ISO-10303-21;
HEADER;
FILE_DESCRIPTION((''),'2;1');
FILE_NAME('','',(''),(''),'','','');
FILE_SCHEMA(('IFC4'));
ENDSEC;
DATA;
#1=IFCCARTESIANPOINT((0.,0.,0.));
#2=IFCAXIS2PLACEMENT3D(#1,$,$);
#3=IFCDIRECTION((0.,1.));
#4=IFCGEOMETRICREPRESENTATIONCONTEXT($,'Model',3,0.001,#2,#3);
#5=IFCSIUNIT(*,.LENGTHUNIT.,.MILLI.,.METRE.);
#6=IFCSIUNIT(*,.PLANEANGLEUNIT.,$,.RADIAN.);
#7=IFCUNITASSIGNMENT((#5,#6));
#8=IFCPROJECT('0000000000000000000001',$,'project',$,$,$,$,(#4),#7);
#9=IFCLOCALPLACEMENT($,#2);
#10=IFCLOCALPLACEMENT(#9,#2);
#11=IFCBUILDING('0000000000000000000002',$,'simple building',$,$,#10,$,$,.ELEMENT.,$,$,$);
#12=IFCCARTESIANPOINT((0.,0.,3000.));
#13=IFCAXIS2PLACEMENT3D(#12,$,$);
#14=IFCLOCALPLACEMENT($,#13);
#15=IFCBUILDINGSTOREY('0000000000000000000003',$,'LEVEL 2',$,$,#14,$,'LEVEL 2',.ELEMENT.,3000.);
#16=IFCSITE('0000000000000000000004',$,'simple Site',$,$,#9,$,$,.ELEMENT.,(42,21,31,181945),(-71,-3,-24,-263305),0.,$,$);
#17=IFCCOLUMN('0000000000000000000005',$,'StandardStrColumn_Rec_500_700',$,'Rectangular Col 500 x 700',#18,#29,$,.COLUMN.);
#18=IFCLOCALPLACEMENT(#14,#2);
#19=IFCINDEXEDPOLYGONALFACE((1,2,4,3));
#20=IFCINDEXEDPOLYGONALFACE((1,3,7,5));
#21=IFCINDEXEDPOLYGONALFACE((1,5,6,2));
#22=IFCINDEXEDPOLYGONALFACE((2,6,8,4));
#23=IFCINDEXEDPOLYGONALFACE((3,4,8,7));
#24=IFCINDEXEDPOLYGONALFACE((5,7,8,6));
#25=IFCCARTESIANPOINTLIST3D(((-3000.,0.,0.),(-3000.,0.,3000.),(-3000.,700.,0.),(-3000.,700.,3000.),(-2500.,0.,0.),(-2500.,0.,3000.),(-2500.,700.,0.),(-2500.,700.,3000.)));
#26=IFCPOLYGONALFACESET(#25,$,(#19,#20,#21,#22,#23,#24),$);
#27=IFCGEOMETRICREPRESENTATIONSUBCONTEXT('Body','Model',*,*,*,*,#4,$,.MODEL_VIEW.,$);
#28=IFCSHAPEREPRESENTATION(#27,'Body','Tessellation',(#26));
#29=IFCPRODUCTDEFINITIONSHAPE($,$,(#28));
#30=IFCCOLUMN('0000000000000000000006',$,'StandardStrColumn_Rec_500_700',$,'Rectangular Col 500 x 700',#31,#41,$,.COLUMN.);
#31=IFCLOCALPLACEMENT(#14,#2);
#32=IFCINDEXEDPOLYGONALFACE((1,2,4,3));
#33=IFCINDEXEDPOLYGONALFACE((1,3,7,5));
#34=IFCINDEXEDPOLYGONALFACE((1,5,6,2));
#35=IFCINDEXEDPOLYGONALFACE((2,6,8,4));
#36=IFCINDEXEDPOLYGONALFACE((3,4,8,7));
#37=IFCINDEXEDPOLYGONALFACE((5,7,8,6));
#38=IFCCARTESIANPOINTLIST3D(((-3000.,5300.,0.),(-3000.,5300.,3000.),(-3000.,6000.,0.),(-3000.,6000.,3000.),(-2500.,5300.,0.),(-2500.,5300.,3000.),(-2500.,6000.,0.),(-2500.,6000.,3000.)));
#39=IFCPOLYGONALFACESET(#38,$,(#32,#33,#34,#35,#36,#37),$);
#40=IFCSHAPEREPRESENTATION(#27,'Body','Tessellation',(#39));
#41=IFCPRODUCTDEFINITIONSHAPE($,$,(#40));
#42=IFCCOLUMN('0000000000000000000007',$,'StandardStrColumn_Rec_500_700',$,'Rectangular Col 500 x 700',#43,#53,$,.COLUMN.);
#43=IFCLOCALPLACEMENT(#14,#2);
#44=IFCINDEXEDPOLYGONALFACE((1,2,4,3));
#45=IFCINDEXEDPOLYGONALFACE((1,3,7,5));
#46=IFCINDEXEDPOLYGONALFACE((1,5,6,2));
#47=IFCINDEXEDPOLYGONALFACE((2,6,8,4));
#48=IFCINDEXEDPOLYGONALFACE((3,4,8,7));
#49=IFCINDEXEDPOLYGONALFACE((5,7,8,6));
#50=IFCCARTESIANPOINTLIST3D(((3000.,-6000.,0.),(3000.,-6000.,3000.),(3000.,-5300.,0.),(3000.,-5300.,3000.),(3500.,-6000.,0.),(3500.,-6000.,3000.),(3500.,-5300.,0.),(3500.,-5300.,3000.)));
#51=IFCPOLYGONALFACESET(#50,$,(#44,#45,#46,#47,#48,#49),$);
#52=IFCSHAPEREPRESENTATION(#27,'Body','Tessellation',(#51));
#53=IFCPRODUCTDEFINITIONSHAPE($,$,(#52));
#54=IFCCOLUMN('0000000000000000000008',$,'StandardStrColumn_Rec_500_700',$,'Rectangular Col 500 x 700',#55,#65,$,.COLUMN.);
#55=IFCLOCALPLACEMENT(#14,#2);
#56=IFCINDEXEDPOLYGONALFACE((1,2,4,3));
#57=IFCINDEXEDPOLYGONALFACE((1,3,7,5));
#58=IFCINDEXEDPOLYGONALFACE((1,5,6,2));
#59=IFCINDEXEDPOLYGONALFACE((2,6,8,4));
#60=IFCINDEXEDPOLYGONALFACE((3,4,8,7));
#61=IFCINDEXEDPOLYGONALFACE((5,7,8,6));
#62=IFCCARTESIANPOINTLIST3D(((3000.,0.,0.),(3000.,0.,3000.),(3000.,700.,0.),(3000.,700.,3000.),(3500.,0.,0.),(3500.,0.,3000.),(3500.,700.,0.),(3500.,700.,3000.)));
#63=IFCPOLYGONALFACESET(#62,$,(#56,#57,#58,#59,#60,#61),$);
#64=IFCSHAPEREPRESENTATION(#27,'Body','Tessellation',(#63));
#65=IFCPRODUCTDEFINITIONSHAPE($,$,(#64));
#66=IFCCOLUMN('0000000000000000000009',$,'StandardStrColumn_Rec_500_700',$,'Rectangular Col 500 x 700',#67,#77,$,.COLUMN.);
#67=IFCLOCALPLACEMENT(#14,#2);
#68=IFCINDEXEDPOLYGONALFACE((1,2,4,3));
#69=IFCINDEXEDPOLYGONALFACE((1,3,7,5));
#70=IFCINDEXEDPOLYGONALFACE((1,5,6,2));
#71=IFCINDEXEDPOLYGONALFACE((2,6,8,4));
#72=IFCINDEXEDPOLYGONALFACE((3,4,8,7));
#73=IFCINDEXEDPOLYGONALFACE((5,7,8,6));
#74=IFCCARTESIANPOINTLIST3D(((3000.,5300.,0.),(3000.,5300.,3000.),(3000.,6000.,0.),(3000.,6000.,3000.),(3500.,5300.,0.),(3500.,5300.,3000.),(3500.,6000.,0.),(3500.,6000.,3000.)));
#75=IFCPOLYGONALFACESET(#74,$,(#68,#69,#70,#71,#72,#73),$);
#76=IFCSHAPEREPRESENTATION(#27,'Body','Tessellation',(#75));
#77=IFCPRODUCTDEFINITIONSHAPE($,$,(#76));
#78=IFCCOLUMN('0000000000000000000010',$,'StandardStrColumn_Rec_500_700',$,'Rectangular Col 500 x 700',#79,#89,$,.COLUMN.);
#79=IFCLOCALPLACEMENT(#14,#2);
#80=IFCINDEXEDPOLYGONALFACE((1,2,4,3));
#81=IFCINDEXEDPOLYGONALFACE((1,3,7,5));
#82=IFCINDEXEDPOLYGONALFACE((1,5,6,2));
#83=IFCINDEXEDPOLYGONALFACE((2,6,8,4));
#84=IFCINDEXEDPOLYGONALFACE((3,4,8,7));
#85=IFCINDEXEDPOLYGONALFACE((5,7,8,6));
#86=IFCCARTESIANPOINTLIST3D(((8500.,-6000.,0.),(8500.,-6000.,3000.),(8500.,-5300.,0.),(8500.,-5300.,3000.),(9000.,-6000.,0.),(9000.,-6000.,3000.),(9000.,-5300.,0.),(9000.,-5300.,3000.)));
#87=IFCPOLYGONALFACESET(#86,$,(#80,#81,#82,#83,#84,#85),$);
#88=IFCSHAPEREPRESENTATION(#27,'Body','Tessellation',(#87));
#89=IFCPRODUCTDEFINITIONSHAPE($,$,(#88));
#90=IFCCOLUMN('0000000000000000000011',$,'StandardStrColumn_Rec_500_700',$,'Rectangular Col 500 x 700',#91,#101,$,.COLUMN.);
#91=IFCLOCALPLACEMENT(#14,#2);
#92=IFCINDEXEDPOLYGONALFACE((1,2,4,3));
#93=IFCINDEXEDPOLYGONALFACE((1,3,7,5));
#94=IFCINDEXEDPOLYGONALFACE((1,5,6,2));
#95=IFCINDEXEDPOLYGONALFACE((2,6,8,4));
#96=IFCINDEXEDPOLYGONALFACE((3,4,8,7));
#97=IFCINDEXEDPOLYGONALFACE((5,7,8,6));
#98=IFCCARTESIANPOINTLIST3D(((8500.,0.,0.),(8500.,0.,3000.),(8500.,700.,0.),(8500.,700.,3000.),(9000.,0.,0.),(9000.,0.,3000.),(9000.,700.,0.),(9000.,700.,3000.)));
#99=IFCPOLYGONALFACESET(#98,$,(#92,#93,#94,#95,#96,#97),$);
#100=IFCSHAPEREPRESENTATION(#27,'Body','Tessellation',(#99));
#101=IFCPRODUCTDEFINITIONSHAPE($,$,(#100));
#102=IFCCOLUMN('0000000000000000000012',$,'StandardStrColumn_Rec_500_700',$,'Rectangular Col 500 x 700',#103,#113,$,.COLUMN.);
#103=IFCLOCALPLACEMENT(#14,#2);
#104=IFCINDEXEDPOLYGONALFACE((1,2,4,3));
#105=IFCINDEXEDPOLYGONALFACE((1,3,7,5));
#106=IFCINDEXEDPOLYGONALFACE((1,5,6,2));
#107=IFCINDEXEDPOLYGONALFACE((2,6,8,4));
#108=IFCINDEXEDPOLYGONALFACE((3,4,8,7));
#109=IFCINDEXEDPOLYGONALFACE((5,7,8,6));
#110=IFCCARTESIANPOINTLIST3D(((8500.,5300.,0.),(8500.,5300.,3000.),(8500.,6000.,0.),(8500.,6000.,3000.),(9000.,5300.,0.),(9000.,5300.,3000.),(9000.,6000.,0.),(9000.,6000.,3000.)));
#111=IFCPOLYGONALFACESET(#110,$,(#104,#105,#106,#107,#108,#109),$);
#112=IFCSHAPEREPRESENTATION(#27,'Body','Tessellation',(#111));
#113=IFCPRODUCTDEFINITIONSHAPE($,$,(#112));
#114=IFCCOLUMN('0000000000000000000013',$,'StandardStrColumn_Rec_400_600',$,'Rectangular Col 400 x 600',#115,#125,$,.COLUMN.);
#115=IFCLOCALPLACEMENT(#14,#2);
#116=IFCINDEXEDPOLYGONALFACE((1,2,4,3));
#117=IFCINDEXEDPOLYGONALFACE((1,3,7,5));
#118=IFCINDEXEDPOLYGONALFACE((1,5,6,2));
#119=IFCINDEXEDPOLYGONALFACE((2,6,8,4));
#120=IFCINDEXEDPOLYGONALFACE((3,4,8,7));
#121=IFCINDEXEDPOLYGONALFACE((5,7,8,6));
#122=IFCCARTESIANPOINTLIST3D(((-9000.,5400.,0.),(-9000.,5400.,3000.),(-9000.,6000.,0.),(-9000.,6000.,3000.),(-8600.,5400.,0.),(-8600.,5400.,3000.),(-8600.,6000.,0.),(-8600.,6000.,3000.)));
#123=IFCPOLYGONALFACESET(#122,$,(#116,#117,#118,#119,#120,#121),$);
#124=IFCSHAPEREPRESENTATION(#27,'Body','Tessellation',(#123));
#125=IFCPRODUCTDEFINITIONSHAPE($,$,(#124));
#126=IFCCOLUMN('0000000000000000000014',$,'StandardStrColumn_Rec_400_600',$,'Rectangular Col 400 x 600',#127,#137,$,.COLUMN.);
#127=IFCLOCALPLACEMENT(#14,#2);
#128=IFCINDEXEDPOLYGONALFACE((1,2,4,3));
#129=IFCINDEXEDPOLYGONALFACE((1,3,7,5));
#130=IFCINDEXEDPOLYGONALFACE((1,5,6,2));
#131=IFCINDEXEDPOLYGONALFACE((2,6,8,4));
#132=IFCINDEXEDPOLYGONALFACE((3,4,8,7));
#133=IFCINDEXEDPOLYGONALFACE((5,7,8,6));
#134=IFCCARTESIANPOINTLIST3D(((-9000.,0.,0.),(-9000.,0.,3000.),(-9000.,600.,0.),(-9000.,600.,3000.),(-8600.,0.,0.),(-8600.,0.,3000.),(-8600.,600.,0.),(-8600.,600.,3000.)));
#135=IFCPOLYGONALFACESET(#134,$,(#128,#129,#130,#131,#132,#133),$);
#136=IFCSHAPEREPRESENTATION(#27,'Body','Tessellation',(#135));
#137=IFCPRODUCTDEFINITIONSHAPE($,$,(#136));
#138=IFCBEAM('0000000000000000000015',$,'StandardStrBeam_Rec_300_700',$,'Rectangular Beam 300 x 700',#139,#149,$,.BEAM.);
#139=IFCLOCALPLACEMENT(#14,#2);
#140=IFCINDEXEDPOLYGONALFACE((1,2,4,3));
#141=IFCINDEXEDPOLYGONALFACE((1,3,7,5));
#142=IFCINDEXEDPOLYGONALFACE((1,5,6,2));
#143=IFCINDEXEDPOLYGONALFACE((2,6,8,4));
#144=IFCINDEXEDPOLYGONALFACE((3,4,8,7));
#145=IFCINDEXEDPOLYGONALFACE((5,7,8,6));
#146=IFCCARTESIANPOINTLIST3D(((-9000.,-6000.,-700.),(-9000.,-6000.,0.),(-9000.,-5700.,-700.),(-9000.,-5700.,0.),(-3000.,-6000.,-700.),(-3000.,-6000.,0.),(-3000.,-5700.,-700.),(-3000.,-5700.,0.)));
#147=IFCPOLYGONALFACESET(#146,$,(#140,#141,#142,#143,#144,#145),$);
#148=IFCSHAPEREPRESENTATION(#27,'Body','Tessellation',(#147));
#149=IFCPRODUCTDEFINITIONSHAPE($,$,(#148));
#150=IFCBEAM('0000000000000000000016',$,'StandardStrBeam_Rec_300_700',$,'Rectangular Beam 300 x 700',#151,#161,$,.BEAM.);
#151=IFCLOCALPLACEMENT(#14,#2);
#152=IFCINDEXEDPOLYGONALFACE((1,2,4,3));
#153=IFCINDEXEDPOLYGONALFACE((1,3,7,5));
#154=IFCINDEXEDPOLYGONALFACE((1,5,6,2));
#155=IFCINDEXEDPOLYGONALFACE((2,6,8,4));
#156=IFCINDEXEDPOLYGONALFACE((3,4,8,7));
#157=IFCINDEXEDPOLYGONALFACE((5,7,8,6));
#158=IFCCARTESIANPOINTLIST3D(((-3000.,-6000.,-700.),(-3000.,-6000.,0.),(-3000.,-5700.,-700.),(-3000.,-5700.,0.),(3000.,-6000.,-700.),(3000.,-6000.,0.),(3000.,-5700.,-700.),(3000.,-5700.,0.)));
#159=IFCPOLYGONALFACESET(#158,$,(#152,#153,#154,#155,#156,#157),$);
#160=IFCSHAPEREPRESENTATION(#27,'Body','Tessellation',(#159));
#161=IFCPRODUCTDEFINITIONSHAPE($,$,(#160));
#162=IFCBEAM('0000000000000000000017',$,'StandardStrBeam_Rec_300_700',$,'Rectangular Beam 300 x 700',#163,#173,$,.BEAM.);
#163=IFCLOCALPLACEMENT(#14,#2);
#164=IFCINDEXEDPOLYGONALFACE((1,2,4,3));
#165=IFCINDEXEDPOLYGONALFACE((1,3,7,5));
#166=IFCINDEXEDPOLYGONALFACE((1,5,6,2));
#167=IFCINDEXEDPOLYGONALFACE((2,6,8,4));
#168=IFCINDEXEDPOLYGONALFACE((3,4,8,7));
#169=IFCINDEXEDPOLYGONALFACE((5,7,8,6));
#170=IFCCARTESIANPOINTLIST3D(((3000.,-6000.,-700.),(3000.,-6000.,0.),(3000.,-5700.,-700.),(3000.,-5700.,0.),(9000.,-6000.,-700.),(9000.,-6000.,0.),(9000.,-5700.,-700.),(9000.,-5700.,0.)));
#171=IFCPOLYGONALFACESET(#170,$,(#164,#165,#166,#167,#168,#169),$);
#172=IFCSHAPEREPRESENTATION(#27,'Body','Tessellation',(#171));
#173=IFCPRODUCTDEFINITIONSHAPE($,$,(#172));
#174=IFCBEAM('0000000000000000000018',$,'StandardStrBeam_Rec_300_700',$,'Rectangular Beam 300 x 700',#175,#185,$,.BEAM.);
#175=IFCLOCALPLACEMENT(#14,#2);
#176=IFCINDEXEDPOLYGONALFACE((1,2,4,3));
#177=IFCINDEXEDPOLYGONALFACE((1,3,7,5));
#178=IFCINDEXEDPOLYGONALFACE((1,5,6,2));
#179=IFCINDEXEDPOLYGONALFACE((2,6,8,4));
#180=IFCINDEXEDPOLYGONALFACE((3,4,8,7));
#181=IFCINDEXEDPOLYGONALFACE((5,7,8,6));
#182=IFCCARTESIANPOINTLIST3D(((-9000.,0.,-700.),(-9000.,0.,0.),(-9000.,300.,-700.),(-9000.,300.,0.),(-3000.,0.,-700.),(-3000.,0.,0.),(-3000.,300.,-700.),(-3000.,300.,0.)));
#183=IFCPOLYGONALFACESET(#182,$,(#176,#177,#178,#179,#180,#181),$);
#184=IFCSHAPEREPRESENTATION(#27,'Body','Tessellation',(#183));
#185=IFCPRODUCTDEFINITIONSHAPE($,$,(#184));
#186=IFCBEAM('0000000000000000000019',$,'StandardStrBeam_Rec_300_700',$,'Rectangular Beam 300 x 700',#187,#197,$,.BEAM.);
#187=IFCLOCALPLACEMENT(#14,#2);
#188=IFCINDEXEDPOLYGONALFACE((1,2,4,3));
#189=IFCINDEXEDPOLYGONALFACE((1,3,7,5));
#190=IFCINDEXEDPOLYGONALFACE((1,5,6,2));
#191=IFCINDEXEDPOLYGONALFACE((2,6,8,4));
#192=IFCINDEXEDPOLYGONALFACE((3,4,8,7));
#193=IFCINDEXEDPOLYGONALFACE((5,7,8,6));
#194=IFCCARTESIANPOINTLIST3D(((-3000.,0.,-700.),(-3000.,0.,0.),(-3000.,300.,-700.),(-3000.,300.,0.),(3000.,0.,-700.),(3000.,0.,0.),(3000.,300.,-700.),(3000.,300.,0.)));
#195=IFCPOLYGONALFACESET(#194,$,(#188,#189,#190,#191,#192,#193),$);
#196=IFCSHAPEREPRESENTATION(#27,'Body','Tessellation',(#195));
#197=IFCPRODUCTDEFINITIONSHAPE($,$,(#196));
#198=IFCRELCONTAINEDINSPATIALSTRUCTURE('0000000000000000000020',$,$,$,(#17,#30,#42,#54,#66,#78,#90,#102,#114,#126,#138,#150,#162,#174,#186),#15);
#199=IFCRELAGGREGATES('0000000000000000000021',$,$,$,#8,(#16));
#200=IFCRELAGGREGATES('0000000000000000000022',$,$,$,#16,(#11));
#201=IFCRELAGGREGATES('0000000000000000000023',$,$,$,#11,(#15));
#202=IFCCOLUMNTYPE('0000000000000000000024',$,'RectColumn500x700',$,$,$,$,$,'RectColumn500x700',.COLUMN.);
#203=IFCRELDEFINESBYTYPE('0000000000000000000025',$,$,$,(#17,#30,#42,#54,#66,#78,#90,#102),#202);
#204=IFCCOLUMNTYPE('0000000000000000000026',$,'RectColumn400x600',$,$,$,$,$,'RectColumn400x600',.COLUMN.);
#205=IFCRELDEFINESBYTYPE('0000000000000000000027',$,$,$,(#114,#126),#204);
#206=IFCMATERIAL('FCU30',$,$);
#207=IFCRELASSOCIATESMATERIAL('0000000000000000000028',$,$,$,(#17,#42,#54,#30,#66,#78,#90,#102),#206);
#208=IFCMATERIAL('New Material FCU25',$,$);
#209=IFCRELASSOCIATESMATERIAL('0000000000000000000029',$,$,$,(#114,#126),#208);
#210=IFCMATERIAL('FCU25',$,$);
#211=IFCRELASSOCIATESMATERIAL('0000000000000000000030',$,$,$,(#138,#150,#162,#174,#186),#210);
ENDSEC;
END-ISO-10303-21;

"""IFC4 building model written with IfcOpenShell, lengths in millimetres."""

from ifc_helpers import new_model, si_unit, direction, frame, origin, origin_with_axes, origin_2d_with_axis, place, context, subcontext, project, spatial, rectangle, extrude, material, material_profile, profile_set, profile_usage, type_object, element, save


model = new_model("IFC4")

# Units and contexts
model_context = context("Model", 3, precision=0.001, world=origin(), true_north=direction((0.0, 1.0)))
body_context = subcontext(model_context, "Body", "Model", "MODEL_VIEW")
ifc_project = project(units=[si_unit("LENGTHUNIT", "METRE", prefix="MILLI"), si_unit("PLANEANGLEUNIT", "RADIAN")], contexts=[model_context])

# Site, building, storey
site_placement = place(None, origin())
site = spatial("IfcSite", under=ifc_project, at=site_placement, Name="simple Site", CompositionType="ELEMENT", RefLatitude=(42, 21, 31, 181945), RefLongitude=(-71, -3, -24, -263305), RefElevation=0.0)
building_placement = place(site_placement, origin())
building = spatial("IfcBuilding", under=site, at=building_placement, Name="simple building", CompositionType="ELEMENT")
storey_placement = place(None, frame((0.0, 0.0, 3000.0)))
storey = spatial("IfcBuildingStorey", under=building, at=storey_placement, Name="LEVEL 2", LongName="LEVEL 2", CompositionType="ELEMENT", Elevation=3000.0)

# Columns
ifc_material_1 = material(Name="FCU30")
ifc_material_profile_1 = material_profile(ifc_material_1, rectangle(XDim=500.0, YDim=700.0, at=origin_2d_with_axis()))
ifc_profile_set_1 = profile_set([ifc_material_profile_1])
ifc_profile_usage_1 = profile_usage(ifc_profile_set_1, cardinal=7)
column_type_1 = type_object("IfcColumnType", Name="RectColumn500x700", ElementType="RectColumn500x700", PredefinedType="COLUMN")
column_1_placement = place(None, frame((-2750.0, 350.0, 3000.0), z_axis=(0.0, 0.0, 1.0), x_axis=(1.0, 0.0, 0.0)))
element("IfcColumn", 1, at=column_1_placement, inside=storey, type_object=column_type_1, material=ifc_profile_usage_1, Name="StandardStrColumn_Rec_500_700", ObjectType="Rectangular Col 500 x 700", PredefinedType="COLUMN", context=body_context, shape_type="SweptSolid", body=[
    extrude(rectangle(XDim=500.0, YDim=700.0, at=origin_2d_with_axis()), origin_with_axes(), (0.0, 0.0, 1.0), 3000.0),
])
ifc_profile_usage_2 = profile_usage(ifc_profile_set_1, cardinal=1)
column_2_placement = place(None, frame((-2750.0, 5650.0, 3000.0), z_axis=(0.0, 0.0, 1.0), x_axis=(1.0, 0.0, 0.0)))
element("IfcColumn", 2, at=column_2_placement, inside=storey, type_object=column_type_1, material=ifc_profile_usage_2, Name="StandardStrColumn_Rec_500_700", ObjectType="Rectangular Col 500 x 700", PredefinedType="COLUMN", context=body_context, shape_type="SweptSolid", body=[
    extrude(rectangle(XDim=500.0, YDim=700.0, at=origin_2d_with_axis()), origin_with_axes(), (0.0, 0.0, 1.0), 3000.0),
])
for number, where, z_axis, x_axis, name in (
    (3, (3250.0, -5650.0, 3000.0), (0.0, 0.0, 1.0), (1.0, 0.0, 0.0), "StandardStrColumn_Rec_500_700"),
    (4, (3250.0, 350.0, 3000.0), (0.0, 0.0, 1.0), (1.0, 0.0, 0.0), "StandardStrColumn_Rec_500_700"),
):
    element("IfcColumn", number, at=place(None, frame(where, z_axis=z_axis, x_axis=x_axis)), inside=storey, type_object=column_type_1, material=ifc_profile_usage_1, Name=name, ObjectType="Rectangular Col 500 x 700", PredefinedType="COLUMN", context=body_context, shape_type="SweptSolid", body=[
        extrude(rectangle(XDim=500.0, YDim=700.0, at=origin_2d_with_axis()), origin_with_axes(), (0.0, 0.0, 1.0), 3000.0),
    ])
column_3_placement = place(None, frame((3250.0, 5650.0, 3000.0), z_axis=(0.0, 0.0, 1.0), x_axis=(1.0, 0.0, 0.0)))
element("IfcColumn", 5, at=column_3_placement, inside=storey, type_object=column_type_1, material=ifc_profile_usage_2, Name="StandardStrColumn_Rec_500_700", ObjectType="Rectangular Col 500 x 700", PredefinedType="COLUMN", context=body_context, shape_type="SweptSolid", body=[
    extrude(rectangle(XDim=500.0, YDim=700.0, at=origin_2d_with_axis()), origin_with_axes(), (0.0, 0.0, 1.0), 3000.0),
])
ifc_profile_usage_3 = profile_usage(ifc_profile_set_1, cardinal=9)
for number, where, z_axis, x_axis, name in (
    (6, (8750.0, -5650.0, 3000.0), (0.0, 0.0, 1.0), (1.0, 0.0, 0.0), "StandardStrColumn_Rec_500_700"),
    (7, (8750.0, 350.0, 3000.0), (0.0, 0.0, 1.0), (1.0, 0.0, 0.0), "StandardStrColumn_Rec_500_700"),
):
    element("IfcColumn", number, at=place(None, frame(where, z_axis=z_axis, x_axis=x_axis)), inside=storey, type_object=column_type_1, material=ifc_profile_usage_3, Name=name, ObjectType="Rectangular Col 500 x 700", PredefinedType="COLUMN", context=body_context, shape_type="SweptSolid", body=[
        extrude(rectangle(XDim=500.0, YDim=700.0, at=origin_2d_with_axis()), origin_with_axes(), (0.0, 0.0, 1.0), 3000.0),
    ])
ifc_profile_usage_4 = profile_usage(ifc_profile_set_1, cardinal=3)
column_4_placement = place(None, frame((8750.0, 5650.0, 3000.0), z_axis=(0.0, 0.0, 1.0), x_axis=(1.0, 0.0, 0.0)))
element("IfcColumn", 8, at=column_4_placement, inside=storey, type_object=column_type_1, material=ifc_profile_usage_4, Name="StandardStrColumn_Rec_500_700", ObjectType="Rectangular Col 500 x 700", PredefinedType="COLUMN", context=body_context, shape_type="SweptSolid", body=[
    extrude(rectangle(XDim=500.0, YDim=700.0, at=origin_2d_with_axis()), origin_with_axes(), (0.0, 0.0, 1.0), 3000.0),
])
ifc_material_2 = material(Name="New Material FCU25")
ifc_material_profile_2 = material_profile(ifc_material_2, rectangle(XDim=400.0, YDim=600.0, at=origin_2d_with_axis()))
ifc_profile_set_2 = profile_set([ifc_material_profile_2])
ifc_profile_usage_5 = profile_usage(ifc_profile_set_2, cardinal=1)
column_type_2 = type_object("IfcColumnType", Name="RectColumn400x600", ElementType="RectColumn400x600", PredefinedType="COLUMN")
column_5_placement = place(None, frame((-8800.0, 5700.0, 3000.0), z_axis=(0.0, 0.0, 1.0), x_axis=(1.0, 0.0, 0.0)))
element("IfcColumn", 9, at=column_5_placement, inside=storey, type_object=column_type_2, material=ifc_profile_usage_5, Name="StandardStrColumn_Rec_400_600", ObjectType="Rectangular Col 400 x 600", PredefinedType="COLUMN", context=body_context, shape_type="SweptSolid", body=[
    extrude(rectangle(XDim=400.0, YDim=600.0, at=origin_2d_with_axis()), origin_with_axes(), (0.0, 0.0, 1.0), 3000.0),
])
ifc_profile_usage_6 = profile_usage(ifc_profile_set_2, cardinal=7)
column_6_placement = place(None, frame((-8800.0, 300.0, 3000.0), z_axis=(0.0, 0.0, 1.0), x_axis=(1.0, 0.0, 0.0)))
element("IfcColumn", 10, at=column_6_placement, inside=storey, type_object=column_type_2, material=ifc_profile_usage_6, Name="StandardStrColumn_Rec_400_600", ObjectType="Rectangular Col 400 x 600", PredefinedType="COLUMN", context=body_context, shape_type="SweptSolid", body=[
    extrude(rectangle(XDim=400.0, YDim=600.0, at=origin_2d_with_axis()), origin_with_axes(), (0.0, 0.0, 1.0), 3000.0),
])

# Beams
ifc_material_3 = material(Name="FCU25")
ifc_material_profile_3 = material_profile(ifc_material_3, rectangle(XDim=300.0, YDim=700.0, at=origin_2d_with_axis()))
ifc_profile_set_3 = profile_set([ifc_material_profile_3])
ifc_profile_usage_7 = profile_usage(ifc_profile_set_3, cardinal=9)
for number, where, z_axis, x_axis, name in (
    (11, (-9000.0, -5850.0, 2650.0), (1.0, 0.0, 0.0), (0.0, -1.0, 0.0), "StandardStrBeam_Rec_300_700"),
    (12, (-3000.0, -5850.0, 2650.0), (1.0, 0.0, 0.0), (0.0, -1.0, 0.0), "StandardStrBeam_Rec_300_700"),
    (13, (3000.0, -5850.0, 2650.0), (1.0, 0.0, 0.0), (0.0, -1.0, 0.0), "StandardStrBeam_Rec_300_700"),
    (14, (-9000.0, 150.0, 2650.0), (1.0, 0.0, 0.0), (0.0, -1.0, 0.0), "StandardStrBeam_Rec_300_700"),
    (15, (-3000.0, 150.0, 2650.0), (1.0, 0.0, 0.0), (0.0, -1.0, 0.0), "StandardStrBeam_Rec_300_700"),
):
    element("IfcBeam", number, at=place(None, frame(where, z_axis=z_axis, x_axis=x_axis)), inside=storey, material=ifc_profile_usage_7, Name=name, ObjectType="Rectangular Beam 300 x 700", PredefinedType="BEAM", context=body_context, shape_type="SweptSolid", body=[
        extrude(rectangle(XDim=300.0, YDim=700.0, at=origin_2d_with_axis()), origin_with_axes(), (0.0, 0.0, 1.0), 6000.0),
    ])

save(model, "model.ifc")
